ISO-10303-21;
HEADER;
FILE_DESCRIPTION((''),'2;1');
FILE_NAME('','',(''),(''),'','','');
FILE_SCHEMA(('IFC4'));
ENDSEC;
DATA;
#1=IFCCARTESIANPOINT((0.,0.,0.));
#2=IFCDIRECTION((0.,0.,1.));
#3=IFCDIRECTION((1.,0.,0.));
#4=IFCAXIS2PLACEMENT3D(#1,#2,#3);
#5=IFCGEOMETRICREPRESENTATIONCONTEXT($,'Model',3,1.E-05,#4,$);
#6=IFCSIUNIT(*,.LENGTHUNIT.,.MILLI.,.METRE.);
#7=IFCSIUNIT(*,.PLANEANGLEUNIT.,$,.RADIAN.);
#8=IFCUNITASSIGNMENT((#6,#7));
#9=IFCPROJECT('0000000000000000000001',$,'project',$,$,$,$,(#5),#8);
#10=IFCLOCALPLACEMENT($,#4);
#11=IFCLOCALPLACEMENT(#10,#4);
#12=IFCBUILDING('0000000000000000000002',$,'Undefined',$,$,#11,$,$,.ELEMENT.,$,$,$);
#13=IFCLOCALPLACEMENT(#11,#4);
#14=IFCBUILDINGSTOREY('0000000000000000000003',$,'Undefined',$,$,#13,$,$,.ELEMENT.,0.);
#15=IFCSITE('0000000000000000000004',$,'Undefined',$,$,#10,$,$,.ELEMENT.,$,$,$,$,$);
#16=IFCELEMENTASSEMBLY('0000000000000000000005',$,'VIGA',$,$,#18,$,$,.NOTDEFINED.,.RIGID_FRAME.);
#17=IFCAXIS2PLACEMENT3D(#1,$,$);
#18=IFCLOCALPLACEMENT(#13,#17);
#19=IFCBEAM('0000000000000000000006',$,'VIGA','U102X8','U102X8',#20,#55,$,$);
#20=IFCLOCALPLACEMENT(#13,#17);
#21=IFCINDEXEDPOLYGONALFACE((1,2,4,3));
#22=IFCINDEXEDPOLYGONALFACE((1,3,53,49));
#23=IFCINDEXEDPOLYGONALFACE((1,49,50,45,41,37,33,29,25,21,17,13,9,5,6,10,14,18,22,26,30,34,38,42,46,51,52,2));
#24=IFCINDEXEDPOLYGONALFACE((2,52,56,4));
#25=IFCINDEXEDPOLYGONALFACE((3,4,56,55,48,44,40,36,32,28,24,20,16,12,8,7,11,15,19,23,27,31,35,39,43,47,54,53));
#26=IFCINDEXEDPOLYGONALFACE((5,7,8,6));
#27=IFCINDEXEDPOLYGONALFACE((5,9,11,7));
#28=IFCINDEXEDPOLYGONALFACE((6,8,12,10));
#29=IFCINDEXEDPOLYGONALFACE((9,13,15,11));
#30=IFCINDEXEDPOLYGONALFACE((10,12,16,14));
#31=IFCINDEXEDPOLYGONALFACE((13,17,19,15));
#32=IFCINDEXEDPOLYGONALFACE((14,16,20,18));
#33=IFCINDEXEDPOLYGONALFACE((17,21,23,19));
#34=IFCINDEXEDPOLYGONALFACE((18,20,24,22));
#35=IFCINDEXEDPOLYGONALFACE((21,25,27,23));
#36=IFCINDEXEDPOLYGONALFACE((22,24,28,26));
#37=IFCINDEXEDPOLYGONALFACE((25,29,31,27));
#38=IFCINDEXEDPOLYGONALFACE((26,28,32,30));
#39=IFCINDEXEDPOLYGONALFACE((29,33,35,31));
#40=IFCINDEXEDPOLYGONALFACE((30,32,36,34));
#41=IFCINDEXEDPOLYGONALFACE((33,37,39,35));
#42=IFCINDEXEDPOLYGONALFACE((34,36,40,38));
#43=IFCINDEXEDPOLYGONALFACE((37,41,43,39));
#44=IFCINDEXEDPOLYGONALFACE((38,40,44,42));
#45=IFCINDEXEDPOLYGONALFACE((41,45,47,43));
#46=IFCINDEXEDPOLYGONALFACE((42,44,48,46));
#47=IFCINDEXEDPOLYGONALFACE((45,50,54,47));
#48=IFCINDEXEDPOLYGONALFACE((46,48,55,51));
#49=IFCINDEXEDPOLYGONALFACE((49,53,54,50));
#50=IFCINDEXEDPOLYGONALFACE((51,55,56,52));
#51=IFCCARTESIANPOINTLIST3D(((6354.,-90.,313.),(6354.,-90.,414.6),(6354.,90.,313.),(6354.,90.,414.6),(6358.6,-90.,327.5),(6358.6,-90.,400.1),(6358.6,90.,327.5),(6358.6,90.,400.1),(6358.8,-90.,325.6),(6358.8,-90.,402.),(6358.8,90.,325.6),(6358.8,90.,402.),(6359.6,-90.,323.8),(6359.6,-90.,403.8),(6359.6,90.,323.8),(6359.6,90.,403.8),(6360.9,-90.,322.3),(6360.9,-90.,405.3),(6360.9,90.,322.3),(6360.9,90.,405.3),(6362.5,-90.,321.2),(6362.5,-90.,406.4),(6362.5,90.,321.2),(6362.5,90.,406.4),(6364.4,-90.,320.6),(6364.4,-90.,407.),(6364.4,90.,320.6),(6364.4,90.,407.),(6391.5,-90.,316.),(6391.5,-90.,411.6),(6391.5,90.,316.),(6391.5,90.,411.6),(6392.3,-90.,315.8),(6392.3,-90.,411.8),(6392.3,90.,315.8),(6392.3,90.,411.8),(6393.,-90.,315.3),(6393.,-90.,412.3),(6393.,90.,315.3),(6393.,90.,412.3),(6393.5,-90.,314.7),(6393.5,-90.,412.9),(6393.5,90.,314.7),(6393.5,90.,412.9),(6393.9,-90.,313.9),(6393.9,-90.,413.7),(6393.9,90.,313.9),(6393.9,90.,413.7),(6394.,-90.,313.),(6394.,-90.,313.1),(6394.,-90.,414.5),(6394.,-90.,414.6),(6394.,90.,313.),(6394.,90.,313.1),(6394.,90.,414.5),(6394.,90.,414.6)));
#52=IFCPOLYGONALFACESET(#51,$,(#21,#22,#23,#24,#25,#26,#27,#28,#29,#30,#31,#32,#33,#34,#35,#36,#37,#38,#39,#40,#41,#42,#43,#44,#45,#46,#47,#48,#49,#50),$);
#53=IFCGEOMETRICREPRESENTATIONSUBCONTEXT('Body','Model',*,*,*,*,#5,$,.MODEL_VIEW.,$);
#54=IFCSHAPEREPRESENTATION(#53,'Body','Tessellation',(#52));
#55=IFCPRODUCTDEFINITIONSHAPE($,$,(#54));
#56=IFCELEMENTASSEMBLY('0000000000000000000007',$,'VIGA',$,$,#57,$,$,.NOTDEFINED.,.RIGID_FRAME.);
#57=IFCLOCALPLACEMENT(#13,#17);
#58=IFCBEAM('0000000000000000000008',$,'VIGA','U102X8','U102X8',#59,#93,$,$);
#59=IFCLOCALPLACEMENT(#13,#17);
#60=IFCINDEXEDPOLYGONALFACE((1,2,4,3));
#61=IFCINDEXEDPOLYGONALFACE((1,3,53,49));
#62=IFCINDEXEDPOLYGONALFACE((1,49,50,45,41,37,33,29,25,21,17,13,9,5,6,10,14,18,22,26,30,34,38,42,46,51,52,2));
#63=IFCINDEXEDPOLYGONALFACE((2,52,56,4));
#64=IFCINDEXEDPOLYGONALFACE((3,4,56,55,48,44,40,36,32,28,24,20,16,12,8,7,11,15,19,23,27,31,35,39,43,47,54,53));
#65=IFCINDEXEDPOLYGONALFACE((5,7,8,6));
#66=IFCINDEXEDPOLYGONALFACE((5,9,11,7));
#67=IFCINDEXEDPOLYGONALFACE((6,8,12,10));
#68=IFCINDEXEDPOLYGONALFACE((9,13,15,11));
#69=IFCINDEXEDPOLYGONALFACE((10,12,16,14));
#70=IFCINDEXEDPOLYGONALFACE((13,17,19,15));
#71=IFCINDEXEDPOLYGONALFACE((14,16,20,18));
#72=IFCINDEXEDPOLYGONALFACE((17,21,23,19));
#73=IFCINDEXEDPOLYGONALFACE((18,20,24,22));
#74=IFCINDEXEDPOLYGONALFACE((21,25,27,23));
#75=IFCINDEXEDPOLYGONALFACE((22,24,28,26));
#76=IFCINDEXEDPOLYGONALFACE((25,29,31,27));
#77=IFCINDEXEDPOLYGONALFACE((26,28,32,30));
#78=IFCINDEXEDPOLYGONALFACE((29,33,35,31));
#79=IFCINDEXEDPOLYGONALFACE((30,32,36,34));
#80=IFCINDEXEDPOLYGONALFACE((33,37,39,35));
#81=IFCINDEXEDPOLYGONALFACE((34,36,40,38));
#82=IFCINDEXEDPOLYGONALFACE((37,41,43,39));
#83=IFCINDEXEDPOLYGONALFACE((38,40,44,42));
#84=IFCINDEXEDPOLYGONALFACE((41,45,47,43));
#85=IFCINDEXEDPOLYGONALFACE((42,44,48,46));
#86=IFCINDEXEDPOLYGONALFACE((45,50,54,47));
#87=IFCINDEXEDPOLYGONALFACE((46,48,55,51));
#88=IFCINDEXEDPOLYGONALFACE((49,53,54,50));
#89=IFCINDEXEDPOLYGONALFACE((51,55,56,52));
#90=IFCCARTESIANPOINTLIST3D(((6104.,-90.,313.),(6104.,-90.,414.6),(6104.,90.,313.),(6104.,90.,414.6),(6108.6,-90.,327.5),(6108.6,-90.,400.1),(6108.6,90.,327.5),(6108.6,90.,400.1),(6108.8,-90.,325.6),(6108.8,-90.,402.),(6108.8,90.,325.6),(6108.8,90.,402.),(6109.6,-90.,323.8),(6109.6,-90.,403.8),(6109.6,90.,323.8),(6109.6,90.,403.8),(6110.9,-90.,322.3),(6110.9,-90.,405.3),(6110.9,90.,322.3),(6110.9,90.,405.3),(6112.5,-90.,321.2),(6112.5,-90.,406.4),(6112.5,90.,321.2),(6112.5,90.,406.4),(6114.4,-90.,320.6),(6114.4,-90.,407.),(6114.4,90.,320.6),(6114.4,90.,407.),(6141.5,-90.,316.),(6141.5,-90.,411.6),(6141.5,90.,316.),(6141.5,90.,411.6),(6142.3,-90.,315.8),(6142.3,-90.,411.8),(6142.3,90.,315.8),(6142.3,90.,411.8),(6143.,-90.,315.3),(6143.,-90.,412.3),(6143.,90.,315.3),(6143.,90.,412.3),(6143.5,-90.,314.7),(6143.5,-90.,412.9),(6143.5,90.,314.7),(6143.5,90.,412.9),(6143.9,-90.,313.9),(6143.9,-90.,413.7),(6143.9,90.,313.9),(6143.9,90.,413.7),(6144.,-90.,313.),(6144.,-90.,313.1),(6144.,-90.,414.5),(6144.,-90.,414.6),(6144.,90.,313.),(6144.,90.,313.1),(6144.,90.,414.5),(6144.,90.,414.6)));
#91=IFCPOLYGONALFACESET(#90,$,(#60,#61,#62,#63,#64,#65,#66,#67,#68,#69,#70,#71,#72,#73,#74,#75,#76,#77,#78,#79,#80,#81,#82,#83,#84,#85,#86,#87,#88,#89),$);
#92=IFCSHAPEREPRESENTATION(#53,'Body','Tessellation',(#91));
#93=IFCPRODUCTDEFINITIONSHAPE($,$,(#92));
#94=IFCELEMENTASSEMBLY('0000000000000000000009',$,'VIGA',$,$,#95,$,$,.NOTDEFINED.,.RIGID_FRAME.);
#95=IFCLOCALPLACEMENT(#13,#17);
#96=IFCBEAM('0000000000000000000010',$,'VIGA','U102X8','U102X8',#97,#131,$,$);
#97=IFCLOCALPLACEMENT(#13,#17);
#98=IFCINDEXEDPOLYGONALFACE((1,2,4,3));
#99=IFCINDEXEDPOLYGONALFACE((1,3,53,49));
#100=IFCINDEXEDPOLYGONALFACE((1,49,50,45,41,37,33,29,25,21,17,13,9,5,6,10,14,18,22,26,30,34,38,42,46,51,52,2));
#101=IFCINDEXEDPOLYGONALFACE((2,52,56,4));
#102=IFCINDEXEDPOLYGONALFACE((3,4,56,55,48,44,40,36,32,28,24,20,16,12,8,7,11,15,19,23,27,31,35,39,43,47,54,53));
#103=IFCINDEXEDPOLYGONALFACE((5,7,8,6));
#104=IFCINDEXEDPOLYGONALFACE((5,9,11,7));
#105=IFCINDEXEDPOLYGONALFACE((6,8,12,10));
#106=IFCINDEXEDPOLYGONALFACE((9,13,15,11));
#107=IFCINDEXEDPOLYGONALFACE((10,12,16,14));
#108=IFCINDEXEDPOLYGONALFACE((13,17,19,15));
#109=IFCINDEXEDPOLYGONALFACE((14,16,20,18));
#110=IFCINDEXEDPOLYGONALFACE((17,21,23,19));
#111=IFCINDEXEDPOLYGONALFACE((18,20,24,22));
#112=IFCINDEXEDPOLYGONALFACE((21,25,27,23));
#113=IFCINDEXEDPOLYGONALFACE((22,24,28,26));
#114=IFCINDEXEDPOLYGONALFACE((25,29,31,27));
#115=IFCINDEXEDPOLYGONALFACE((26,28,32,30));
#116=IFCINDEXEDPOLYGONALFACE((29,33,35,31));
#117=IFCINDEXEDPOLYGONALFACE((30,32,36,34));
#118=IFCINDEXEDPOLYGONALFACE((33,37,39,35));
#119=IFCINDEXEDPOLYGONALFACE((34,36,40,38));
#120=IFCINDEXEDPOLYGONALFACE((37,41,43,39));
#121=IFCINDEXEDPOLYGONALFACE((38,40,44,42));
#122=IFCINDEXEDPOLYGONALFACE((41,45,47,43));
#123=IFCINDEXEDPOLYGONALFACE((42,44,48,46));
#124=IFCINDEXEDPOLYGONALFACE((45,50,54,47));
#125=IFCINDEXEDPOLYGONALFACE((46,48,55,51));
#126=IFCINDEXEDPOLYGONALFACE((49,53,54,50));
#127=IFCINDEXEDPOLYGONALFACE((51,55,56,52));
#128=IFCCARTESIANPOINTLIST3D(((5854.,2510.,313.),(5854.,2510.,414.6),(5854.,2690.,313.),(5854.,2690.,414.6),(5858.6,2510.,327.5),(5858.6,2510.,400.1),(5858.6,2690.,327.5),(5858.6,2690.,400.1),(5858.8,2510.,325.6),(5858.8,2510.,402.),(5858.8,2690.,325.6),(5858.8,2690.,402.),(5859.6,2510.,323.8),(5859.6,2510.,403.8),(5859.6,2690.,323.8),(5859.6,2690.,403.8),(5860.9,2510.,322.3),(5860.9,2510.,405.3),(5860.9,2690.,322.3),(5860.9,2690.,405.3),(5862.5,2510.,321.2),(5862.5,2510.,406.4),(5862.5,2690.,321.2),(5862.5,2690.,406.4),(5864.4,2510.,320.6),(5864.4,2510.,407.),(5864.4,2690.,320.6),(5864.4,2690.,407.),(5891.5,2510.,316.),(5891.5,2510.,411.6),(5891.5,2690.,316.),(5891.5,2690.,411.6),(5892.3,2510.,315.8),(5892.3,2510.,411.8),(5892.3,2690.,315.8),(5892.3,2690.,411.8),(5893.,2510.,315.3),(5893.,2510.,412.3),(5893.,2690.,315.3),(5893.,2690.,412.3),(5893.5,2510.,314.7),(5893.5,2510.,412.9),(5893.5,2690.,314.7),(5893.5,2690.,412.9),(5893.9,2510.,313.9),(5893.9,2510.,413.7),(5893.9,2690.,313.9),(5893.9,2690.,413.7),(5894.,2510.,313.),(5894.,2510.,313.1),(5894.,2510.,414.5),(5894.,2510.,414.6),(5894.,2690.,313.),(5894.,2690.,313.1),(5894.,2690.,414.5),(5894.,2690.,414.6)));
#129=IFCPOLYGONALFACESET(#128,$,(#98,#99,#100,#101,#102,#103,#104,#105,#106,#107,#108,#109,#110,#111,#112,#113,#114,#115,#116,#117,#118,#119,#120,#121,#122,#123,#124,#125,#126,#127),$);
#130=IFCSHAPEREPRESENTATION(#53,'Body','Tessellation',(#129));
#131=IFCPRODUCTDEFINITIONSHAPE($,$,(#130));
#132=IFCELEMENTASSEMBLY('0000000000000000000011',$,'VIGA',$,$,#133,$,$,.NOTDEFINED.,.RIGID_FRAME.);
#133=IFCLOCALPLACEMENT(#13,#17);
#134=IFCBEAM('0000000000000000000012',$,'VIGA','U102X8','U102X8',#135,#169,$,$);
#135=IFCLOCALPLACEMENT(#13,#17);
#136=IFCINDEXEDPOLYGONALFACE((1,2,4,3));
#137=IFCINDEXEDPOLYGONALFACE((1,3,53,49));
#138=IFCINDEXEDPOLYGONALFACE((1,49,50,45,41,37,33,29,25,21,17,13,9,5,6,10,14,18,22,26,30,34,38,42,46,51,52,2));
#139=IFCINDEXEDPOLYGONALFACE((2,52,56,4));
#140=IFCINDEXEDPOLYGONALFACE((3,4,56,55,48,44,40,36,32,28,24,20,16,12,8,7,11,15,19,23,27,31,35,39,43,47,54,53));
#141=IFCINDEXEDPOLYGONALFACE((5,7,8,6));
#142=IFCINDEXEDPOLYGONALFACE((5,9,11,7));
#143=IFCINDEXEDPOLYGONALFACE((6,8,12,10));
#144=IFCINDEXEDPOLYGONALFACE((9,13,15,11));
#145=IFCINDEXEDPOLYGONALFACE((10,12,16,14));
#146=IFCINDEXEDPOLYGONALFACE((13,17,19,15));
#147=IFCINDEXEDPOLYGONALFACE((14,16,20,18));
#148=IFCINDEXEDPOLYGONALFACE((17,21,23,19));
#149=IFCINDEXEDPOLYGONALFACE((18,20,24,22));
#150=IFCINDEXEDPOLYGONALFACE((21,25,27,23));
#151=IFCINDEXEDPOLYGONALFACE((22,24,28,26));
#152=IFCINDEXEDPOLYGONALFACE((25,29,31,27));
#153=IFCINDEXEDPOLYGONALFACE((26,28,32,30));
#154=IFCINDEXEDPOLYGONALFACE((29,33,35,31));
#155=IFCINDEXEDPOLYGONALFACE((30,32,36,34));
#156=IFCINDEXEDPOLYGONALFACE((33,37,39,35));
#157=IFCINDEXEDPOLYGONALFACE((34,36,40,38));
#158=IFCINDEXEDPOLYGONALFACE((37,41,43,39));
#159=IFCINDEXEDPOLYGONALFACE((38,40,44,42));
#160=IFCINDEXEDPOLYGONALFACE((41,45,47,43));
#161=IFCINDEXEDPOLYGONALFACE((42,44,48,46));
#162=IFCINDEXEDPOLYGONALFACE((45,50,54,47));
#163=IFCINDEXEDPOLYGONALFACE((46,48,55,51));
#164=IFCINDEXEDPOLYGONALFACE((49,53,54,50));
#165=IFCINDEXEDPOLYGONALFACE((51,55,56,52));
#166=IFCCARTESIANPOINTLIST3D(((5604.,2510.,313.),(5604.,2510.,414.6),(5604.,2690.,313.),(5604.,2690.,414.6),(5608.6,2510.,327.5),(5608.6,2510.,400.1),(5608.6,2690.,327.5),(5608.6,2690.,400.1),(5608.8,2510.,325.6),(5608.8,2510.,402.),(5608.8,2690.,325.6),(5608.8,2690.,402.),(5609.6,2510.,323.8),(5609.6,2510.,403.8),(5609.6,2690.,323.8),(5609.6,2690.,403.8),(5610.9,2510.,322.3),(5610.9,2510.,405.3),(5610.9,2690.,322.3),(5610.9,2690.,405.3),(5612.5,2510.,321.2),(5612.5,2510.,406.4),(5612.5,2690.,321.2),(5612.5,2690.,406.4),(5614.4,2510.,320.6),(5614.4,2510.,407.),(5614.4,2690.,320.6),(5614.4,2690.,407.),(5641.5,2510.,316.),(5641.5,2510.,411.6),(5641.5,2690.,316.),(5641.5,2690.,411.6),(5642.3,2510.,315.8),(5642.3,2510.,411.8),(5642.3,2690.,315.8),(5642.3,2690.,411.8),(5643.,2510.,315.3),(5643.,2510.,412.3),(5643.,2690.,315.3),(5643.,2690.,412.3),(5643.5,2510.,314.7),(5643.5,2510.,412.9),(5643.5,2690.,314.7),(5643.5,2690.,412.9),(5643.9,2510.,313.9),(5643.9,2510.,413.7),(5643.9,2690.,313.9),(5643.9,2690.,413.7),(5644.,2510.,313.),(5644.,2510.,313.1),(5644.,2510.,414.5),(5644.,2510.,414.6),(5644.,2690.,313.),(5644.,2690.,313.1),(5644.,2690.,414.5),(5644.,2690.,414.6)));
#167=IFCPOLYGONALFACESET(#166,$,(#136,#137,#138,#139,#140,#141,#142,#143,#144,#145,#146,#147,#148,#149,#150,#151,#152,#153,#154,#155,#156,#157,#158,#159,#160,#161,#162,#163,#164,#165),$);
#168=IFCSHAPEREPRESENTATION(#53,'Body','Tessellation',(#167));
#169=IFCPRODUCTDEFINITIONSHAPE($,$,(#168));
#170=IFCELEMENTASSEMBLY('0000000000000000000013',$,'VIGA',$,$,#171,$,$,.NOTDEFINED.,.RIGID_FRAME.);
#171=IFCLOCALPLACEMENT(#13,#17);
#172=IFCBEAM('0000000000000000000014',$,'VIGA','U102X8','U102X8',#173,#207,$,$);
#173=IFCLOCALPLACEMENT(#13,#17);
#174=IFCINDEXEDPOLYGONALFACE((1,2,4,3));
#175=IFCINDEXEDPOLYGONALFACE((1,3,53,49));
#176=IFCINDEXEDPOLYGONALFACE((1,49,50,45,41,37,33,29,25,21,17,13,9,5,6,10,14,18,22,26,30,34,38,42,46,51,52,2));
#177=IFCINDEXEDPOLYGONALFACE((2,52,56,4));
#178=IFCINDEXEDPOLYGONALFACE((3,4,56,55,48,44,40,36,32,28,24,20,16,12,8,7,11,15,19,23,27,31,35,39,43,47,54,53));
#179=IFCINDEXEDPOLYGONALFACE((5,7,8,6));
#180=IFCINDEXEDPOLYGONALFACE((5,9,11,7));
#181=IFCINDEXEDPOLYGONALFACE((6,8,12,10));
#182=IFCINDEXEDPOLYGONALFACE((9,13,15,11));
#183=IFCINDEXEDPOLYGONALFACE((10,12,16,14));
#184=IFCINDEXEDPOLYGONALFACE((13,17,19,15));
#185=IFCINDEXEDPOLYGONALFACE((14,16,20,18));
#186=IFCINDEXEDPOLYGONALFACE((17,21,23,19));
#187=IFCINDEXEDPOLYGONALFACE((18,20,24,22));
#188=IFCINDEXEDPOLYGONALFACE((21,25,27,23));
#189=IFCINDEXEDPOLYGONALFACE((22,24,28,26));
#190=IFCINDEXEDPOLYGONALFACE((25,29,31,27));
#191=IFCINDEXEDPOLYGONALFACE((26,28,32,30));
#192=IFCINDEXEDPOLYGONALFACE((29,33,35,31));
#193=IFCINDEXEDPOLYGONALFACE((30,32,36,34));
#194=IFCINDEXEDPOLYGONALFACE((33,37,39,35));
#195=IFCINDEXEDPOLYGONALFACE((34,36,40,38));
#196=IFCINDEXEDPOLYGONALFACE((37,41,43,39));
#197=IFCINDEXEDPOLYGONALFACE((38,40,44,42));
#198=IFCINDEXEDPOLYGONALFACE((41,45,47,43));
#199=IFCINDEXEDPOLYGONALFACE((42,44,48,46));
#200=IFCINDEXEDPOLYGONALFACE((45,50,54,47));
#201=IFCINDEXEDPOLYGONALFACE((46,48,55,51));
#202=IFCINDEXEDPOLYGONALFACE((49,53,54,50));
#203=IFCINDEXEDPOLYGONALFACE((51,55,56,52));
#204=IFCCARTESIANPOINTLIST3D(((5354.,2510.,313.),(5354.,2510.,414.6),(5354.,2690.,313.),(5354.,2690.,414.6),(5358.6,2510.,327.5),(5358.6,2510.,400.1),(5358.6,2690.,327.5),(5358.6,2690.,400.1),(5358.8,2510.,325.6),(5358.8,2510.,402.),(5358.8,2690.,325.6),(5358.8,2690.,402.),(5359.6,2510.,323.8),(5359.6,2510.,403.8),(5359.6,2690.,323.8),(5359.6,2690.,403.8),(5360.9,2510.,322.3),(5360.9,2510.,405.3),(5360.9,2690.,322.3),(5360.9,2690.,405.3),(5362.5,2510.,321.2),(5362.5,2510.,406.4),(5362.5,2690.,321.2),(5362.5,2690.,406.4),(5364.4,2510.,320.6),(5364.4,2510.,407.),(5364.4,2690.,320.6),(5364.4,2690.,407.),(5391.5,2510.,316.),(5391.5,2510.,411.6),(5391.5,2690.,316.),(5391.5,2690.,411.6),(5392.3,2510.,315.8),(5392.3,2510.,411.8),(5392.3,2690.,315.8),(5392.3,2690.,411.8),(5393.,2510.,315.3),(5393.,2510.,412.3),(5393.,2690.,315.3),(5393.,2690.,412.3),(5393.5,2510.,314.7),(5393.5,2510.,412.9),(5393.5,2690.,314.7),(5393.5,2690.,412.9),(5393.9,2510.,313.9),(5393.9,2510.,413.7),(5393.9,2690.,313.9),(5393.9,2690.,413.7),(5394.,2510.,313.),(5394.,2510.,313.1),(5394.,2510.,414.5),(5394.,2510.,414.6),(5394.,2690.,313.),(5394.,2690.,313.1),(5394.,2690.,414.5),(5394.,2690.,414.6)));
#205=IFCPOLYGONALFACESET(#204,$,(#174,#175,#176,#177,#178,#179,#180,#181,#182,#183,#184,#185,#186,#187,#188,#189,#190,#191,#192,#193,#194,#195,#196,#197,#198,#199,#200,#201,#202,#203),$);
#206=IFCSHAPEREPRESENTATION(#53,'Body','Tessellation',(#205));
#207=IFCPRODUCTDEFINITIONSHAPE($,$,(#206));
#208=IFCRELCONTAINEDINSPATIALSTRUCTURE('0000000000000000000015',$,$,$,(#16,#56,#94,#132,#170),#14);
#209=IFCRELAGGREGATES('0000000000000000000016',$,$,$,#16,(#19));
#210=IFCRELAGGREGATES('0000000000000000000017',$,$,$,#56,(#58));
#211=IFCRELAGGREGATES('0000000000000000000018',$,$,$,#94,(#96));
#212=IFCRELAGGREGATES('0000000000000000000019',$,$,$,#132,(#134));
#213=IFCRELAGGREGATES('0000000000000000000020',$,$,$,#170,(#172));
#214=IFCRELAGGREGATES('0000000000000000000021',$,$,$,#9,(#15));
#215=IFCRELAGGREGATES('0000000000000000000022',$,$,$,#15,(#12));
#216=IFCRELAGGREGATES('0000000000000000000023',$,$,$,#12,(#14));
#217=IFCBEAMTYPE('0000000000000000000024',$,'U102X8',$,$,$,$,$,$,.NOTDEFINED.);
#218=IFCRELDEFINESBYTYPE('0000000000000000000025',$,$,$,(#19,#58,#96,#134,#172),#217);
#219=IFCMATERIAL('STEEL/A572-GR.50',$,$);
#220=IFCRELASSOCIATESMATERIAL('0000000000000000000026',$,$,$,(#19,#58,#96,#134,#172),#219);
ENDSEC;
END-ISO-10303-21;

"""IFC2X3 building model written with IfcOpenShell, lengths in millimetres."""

from ifc_helpers import new_model, si_unit, frame, origin_with_axes, origin_2d_with_axis, place, context, subcontext, project, spatial, u_section, extrude, material, type_object, element, aggregate, save


model = new_model("IFC2X3")

# Units and contexts
model_context = context("Model", 3, precision=1e-05, world=origin_with_axes())
body_context = subcontext(model_context, "Body", "Model", "MODEL_VIEW")
ifc_project = project(units=[si_unit("LENGTHUNIT", "METRE", prefix="MILLI"), si_unit("PLANEANGLEUNIT", "RADIAN")], contexts=[model_context])

# Site, building, storey
site_placement = place(None, origin_with_axes())
site = spatial("IfcSite", under=ifc_project, at=site_placement, Name="Undefined", CompositionType="ELEMENT")
building_placement = place(site_placement, origin_with_axes())
building = spatial("IfcBuilding", under=site, at=building_placement, Name="Undefined", CompositionType="ELEMENT")
storey_placement = place(building_placement, origin_with_axes())
storey = spatial("IfcBuildingStorey", under=building, at=storey_placement, Name="Undefined", CompositionType="ELEMENT", Elevation=0.0)

# Element assemblies, beams
ifc_material_1 = material(Name="STEEL/A572-GR.50")
beam_type_1 = type_object("IfcBeamType", Name="U102X8", PredefinedType="NOTDEFINED")
assembly_1_placement = place(storey_placement, origin_with_axes())
assembly_1 = element("IfcElementAssembly", 1, at=assembly_1_placement, inside=storey, Name="VIGA", AssemblyPlace="NOTDEFINED", PredefinedType="RIGID_FRAME")
beam_1_placement = place(assembly_1_placement, frame((6374.0, -90.0, 363.8), z_axis=(0.0, 0.0, 1.0), x_axis=(0.0, 1.0, 0.0)))
beam_1 = element("IfcBeam", 2, at=beam_1_placement, type_object=beam_type_1, material=ifc_material_1, Name="VIGA", Description="U102X8", ObjectType="U102X8", context=body_context, shape_type="SweptSolid", body=[
    extrude(u_section(Depth=101.6, FlangeWidth=40.0, WebThickness=4.6, FlangeThickness=6.0, FilletRadius=7.0, EdgeRadius=3.0, FlangeSlope=0.16839, at=origin_2d_with_axis()), frame((180.0, 0.0, 0.0), z_axis=(-1.0, 0.0, 0.0), x_axis=(0.0, -1.0, 0.0)), (0.0, 0.0, 1.0), 180.0),
])
aggregate(assembly_1, [beam_1])
assembly_2_placement = place(storey_placement, origin_with_axes())
assembly_2 = element("IfcElementAssembly", 3, at=assembly_2_placement, inside=storey, Name="VIGA", AssemblyPlace="NOTDEFINED", PredefinedType="RIGID_FRAME")
beam_2_placement = place(assembly_2_placement, frame((6124.0, -90.0, 363.8), z_axis=(0.0, 0.0, 1.0), x_axis=(0.0, 1.0, 0.0)))
beam_2 = element("IfcBeam", 4, at=beam_2_placement, type_object=beam_type_1, material=ifc_material_1, Name="VIGA", Description="U102X8", ObjectType="U102X8", context=body_context, shape_type="SweptSolid", body=[
    extrude(u_section(Depth=101.6, FlangeWidth=40.0, WebThickness=4.6, FlangeThickness=6.0, FilletRadius=7.0, EdgeRadius=3.0, FlangeSlope=0.16839, at=origin_2d_with_axis()), frame((180.0, 0.0, 0.0), z_axis=(-1.0, 0.0, 0.0), x_axis=(0.0, -1.0, 0.0)), (0.0, 0.0, 1.0), 180.0),
])
aggregate(assembly_2, [beam_2])
assembly_3_placement = place(storey_placement, origin_with_axes())
assembly_3 = element("IfcElementAssembly", 5, at=assembly_3_placement, inside=storey, Name="VIGA", AssemblyPlace="NOTDEFINED", PredefinedType="RIGID_FRAME")
beam_3_placement = place(assembly_3_placement, frame((5874.0, 2510.0, 363.8), z_axis=(0.0, 0.0, 1.0), x_axis=(0.0, 1.0, 0.0)))
beam_3 = element("IfcBeam", 6, at=beam_3_placement, type_object=beam_type_1, material=ifc_material_1, Name="VIGA", Description="U102X8", ObjectType="U102X8", context=body_context, shape_type="SweptSolid", body=[
    extrude(u_section(Depth=101.6, FlangeWidth=40.0, WebThickness=4.6, FlangeThickness=6.0, FilletRadius=7.0, EdgeRadius=3.0, FlangeSlope=0.16839, at=origin_2d_with_axis()), frame((180.0, 0.0, 0.0), z_axis=(-1.0, 0.0, 0.0), x_axis=(0.0, -1.0, 0.0)), (0.0, 0.0, 1.0), 180.0),
])
aggregate(assembly_3, [beam_3])
assembly_4_placement = place(storey_placement, origin_with_axes())
assembly_4 = element("IfcElementAssembly", 7, at=assembly_4_placement, inside=storey, Name="VIGA", AssemblyPlace="NOTDEFINED", PredefinedType="RIGID_FRAME")
beam_4_placement = place(assembly_4_placement, frame((5624.0, 2510.0, 363.8), z_axis=(0.0, 0.0, 1.0), x_axis=(0.0, 1.0, 0.0)))
beam_4 = element("IfcBeam", 8, at=beam_4_placement, type_object=beam_type_1, material=ifc_material_1, Name="VIGA", Description="U102X8", ObjectType="U102X8", context=body_context, shape_type="SweptSolid", body=[
    extrude(u_section(Depth=101.6, FlangeWidth=40.0, WebThickness=4.6, FlangeThickness=6.0, FilletRadius=7.0, EdgeRadius=3.0, FlangeSlope=0.16839, at=origin_2d_with_axis()), frame((180.0, 0.0, 0.0), z_axis=(-1.0, 0.0, 0.0), x_axis=(0.0, -1.0, 0.0)), (0.0, 0.0, 1.0), 180.0),
])
aggregate(assembly_4, [beam_4])
assembly_5_placement = place(storey_placement, origin_with_axes())
assembly_5 = element("IfcElementAssembly", 9, at=assembly_5_placement, inside=storey, Name="VIGA", AssemblyPlace="NOTDEFINED", PredefinedType="RIGID_FRAME")
beam_5_placement = place(assembly_5_placement, frame((5374.0, 2510.0, 363.8), z_axis=(0.0, 0.0, 1.0), x_axis=(0.0, 1.0, 0.0)))
beam_5 = element("IfcBeam", 10, at=beam_5_placement, type_object=beam_type_1, material=ifc_material_1, Name="VIGA", Description="U102X8", ObjectType="U102X8", context=body_context, shape_type="SweptSolid", body=[
    extrude(u_section(Depth=101.6, FlangeWidth=40.0, WebThickness=4.6, FlangeThickness=6.0, FilletRadius=7.0, EdgeRadius=3.0, FlangeSlope=0.16839, at=origin_2d_with_axis()), frame((180.0, 0.0, 0.0), z_axis=(-1.0, 0.0, 0.0), x_axis=(0.0, -1.0, 0.0)), (0.0, 0.0, 1.0), 180.0),
])
aggregate(assembly_5, [beam_5])

save(model, "model.ifc")
